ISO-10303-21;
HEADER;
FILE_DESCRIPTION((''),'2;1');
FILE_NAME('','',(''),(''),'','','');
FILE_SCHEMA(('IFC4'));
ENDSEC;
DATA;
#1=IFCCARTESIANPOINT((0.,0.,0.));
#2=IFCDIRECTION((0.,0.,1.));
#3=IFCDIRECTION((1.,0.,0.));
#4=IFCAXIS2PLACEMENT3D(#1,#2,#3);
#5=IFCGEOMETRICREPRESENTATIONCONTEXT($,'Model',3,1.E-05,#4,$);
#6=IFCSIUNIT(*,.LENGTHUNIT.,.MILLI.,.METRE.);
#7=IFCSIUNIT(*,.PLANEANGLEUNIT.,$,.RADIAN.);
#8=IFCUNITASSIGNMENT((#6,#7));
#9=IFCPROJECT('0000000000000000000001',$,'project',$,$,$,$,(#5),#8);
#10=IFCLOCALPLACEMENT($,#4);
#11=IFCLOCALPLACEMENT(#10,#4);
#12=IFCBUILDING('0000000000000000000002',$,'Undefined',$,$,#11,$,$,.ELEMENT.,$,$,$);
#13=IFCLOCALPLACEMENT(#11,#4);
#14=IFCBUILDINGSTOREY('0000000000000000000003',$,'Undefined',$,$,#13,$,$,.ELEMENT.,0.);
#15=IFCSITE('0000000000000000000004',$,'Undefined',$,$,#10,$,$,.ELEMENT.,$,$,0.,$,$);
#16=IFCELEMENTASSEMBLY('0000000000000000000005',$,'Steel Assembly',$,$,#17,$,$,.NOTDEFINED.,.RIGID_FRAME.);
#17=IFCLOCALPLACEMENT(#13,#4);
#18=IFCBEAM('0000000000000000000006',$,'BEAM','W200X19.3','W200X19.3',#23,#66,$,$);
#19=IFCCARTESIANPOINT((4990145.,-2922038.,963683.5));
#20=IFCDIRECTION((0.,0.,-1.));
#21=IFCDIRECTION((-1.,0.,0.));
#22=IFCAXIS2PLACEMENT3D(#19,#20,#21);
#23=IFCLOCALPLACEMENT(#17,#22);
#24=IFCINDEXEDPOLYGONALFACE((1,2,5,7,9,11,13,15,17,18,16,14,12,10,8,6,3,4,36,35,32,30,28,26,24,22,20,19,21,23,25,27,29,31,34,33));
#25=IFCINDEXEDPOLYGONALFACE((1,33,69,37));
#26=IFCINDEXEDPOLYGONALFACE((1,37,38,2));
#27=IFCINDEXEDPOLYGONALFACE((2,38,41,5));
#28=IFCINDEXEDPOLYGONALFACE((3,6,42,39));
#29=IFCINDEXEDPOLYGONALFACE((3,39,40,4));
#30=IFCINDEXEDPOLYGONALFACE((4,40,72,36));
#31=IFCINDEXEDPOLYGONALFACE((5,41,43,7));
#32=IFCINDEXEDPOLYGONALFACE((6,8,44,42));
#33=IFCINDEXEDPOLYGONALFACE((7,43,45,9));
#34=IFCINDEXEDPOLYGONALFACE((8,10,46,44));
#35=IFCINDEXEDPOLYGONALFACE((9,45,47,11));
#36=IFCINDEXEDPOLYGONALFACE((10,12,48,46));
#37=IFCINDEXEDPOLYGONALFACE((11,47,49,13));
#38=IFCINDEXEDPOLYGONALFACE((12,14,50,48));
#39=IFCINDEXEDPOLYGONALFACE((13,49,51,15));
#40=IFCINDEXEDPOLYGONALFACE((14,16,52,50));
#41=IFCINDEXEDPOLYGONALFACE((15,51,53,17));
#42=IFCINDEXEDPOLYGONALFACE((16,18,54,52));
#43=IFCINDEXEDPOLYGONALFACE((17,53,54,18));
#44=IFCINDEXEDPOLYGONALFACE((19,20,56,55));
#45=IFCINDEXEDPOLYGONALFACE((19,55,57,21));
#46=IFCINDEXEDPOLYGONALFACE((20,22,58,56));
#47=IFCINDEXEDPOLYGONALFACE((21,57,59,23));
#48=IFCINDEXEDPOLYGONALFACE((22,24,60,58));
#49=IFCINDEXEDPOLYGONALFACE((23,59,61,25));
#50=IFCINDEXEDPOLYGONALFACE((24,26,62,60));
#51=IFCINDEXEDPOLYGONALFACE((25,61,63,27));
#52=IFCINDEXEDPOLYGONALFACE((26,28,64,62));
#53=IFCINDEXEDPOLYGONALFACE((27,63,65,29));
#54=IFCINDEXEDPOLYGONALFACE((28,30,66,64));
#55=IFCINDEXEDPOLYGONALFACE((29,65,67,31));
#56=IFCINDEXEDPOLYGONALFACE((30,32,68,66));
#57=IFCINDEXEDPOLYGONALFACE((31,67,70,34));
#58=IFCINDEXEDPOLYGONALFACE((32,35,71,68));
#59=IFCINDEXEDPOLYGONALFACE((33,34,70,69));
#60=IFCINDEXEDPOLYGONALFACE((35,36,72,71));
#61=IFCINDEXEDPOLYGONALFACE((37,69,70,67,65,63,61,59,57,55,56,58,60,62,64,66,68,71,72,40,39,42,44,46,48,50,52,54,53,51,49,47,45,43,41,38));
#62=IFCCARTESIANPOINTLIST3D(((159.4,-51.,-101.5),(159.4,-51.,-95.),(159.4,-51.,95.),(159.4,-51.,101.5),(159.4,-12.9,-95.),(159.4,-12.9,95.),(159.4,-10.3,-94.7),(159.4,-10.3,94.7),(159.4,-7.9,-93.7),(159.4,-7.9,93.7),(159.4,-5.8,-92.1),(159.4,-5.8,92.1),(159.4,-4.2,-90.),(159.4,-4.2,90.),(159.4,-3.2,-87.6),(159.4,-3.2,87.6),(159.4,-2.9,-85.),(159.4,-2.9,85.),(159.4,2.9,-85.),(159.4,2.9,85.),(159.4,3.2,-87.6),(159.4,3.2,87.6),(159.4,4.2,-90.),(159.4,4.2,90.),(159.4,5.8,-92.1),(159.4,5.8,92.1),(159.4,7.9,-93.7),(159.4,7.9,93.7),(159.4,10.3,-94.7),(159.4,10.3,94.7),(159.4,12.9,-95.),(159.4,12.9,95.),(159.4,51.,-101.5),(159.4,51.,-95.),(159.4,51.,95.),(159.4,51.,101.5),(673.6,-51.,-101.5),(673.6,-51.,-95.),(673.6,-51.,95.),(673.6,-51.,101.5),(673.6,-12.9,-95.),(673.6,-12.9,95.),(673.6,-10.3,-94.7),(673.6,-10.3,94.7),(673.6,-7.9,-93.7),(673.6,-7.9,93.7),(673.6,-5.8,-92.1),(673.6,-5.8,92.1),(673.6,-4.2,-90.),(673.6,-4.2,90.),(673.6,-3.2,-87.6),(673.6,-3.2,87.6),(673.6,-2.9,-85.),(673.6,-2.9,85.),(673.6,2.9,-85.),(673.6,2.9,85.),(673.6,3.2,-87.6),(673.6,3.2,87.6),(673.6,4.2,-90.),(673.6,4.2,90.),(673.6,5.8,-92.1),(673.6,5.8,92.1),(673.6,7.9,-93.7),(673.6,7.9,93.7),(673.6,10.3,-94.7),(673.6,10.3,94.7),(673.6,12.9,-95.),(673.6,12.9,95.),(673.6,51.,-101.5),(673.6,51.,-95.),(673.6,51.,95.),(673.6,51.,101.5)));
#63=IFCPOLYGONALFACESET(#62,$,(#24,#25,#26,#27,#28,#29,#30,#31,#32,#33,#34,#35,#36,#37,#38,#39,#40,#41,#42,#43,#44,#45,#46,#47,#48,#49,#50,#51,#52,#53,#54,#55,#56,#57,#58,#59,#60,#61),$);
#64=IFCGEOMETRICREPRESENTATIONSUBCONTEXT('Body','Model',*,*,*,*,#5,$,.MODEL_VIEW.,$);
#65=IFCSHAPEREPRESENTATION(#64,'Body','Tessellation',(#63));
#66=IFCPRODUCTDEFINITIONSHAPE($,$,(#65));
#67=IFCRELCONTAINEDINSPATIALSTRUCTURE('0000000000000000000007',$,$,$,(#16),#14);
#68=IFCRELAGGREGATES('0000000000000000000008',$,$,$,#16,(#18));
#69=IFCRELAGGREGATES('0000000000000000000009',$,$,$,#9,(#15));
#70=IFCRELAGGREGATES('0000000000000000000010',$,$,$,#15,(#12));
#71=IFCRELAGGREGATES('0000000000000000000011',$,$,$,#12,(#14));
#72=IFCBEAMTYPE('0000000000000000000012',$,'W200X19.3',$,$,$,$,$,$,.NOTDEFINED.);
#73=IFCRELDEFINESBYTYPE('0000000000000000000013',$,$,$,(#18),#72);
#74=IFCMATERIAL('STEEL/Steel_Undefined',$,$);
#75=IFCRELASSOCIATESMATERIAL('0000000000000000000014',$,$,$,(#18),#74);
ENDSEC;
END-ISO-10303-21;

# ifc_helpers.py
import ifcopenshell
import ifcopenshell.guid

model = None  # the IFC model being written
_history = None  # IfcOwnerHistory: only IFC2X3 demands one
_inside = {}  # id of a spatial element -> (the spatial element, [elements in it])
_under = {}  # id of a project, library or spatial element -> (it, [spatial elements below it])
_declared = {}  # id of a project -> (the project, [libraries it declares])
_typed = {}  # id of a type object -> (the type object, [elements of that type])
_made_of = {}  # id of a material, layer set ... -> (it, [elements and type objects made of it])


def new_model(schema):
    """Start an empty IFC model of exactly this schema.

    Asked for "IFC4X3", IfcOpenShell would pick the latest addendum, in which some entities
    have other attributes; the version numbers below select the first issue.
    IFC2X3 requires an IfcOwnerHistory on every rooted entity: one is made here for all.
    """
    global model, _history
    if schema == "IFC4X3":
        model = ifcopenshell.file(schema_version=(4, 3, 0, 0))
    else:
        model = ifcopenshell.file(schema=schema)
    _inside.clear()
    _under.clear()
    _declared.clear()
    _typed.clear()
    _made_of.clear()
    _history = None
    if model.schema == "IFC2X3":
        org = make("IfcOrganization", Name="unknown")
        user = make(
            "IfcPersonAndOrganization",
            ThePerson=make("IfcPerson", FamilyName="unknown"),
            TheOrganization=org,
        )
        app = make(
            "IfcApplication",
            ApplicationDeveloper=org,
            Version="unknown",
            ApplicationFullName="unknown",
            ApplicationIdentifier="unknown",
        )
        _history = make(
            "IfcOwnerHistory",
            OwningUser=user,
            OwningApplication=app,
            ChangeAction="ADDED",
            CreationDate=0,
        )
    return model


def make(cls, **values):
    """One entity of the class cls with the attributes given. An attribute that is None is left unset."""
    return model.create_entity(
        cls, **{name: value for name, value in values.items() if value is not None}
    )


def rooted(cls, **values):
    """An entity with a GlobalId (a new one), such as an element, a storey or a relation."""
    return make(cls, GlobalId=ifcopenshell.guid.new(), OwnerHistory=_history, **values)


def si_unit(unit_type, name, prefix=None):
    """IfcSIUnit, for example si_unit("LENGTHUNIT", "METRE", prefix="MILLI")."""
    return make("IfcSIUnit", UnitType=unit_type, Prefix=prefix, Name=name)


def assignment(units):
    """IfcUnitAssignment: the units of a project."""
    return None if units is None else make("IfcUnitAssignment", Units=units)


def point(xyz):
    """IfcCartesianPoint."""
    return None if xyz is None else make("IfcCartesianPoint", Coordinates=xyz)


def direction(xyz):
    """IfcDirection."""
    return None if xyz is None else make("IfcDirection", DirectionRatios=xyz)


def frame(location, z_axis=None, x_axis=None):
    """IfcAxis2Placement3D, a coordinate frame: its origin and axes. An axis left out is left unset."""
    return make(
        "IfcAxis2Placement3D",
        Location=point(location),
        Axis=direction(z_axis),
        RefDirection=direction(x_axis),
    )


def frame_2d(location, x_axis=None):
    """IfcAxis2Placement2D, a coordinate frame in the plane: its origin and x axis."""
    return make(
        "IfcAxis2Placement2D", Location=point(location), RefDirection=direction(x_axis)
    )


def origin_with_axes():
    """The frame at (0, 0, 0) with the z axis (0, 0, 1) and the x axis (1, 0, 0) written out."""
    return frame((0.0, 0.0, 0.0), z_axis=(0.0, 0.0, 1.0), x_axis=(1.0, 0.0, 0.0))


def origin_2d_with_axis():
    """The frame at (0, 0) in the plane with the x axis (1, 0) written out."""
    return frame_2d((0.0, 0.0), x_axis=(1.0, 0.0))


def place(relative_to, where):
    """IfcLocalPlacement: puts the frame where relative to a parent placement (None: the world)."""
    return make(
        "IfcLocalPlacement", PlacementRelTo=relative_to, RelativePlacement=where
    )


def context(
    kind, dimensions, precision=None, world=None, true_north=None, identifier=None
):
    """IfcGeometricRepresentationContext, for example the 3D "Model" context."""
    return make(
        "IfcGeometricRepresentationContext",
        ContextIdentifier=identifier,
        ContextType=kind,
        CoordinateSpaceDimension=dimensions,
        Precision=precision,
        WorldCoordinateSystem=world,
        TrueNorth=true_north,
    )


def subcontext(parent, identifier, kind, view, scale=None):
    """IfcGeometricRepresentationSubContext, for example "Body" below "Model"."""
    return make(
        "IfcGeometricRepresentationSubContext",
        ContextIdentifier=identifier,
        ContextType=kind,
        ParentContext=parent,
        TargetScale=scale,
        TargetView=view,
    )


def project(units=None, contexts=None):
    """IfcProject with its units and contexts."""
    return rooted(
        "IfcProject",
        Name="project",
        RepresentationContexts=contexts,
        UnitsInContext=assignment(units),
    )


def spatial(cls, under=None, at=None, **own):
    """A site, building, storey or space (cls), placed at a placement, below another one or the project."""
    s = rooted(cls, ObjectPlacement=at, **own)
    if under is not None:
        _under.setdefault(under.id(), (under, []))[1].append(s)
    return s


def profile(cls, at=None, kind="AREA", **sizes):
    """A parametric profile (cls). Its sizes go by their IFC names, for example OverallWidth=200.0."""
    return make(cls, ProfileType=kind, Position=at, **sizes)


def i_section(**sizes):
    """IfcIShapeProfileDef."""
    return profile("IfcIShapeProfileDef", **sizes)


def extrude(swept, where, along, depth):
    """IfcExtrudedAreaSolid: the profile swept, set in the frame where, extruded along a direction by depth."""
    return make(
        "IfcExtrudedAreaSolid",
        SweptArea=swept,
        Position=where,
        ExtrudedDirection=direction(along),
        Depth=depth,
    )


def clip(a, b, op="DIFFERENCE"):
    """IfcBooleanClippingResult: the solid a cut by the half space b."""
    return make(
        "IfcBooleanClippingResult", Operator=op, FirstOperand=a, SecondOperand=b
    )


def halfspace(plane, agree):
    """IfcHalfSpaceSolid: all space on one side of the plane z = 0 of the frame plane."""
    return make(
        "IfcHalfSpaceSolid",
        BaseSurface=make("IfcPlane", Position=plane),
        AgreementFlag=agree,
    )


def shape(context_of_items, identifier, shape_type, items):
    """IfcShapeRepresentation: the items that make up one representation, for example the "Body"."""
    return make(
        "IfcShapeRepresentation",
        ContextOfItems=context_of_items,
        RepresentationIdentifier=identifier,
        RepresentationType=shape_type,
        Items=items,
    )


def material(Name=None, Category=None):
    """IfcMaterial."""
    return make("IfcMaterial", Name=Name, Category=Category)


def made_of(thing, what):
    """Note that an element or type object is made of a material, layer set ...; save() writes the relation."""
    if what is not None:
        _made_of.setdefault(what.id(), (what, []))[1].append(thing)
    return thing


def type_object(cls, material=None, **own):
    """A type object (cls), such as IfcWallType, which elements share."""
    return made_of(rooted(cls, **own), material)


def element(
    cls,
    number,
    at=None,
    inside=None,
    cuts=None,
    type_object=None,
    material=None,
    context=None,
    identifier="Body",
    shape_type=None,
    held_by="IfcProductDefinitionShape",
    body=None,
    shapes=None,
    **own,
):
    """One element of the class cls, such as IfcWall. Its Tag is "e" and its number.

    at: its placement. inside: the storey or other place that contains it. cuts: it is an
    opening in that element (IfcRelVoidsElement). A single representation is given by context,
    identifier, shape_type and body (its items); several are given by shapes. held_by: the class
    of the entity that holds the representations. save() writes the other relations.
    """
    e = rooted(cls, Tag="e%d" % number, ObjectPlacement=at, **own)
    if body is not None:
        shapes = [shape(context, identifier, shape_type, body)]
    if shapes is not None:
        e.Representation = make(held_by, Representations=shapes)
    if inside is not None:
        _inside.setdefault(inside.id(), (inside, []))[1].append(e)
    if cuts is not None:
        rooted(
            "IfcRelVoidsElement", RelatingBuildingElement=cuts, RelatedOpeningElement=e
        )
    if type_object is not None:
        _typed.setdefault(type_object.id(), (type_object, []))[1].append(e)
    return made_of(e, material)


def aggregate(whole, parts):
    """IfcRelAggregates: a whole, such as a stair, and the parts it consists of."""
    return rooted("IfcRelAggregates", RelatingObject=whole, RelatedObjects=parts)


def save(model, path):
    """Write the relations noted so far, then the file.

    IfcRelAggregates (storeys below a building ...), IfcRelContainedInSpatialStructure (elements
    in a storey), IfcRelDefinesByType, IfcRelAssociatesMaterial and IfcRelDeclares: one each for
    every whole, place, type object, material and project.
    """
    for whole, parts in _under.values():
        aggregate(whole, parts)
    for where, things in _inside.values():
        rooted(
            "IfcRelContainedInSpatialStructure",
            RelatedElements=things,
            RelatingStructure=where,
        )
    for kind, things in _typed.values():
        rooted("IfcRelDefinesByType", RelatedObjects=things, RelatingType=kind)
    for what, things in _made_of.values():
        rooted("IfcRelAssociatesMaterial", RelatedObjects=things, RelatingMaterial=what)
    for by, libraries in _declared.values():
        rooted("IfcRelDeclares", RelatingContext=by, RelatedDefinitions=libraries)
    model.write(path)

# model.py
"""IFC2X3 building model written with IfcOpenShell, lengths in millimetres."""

from ifc_helpers import new_model, si_unit, frame, origin_with_axes, origin_2d_with_axis, place, context, subcontext, project, spatial, i_section, extrude, clip, halfspace, material, type_object, element, aggregate, save


model = new_model("IFC2X3")

# Units and contexts
model_context = context("Model", 3, precision=1e-05, world=origin_with_axes())
body_context = subcontext(model_context, "Body", "Model", "MODEL_VIEW")
ifc_project = project(units=[si_unit("LENGTHUNIT", "METRE", prefix="MILLI"), si_unit("PLANEANGLEUNIT", "RADIAN")], contexts=[model_context])

# Site, building, storey
site_placement = place(None, origin_with_axes())
site = spatial("IfcSite", under=ifc_project, at=site_placement, Name="Undefined", CompositionType="ELEMENT", RefElevation=0.0)
building_placement = place(site_placement, origin_with_axes())
building = spatial("IfcBuilding", under=site, at=building_placement, Name="Undefined", CompositionType="ELEMENT")
storey_placement = place(building_placement, origin_with_axes())
storey = spatial("IfcBuildingStorey", under=building, at=storey_placement, Name="Undefined", CompositionType="ELEMENT", Elevation=0.0)

# Element assembly, beam
assembly_1_placement = place(storey_placement, origin_with_axes())
assembly_1 = element("IfcElementAssembly", 1, at=assembly_1_placement, inside=storey, Name="Steel Assembly", AssemblyPlace="NOTDEFINED", PredefinedType="RIGID_FRAME")
ifc_material_1 = material(Name="STEEL/Steel_Undefined")
beam_type = type_object("IfcBeamType", Name="W200X19.3", PredefinedType="NOTDEFINED")
beam_1_placement = place(assembly_1_placement, frame((4990145.0, -2922038.0, 963683.5), z_axis=(0.0, 0.0, -1.0), x_axis=(-1.0, 0.0, 0.0)))
beam_1 = element("IfcBeam", 2, at=beam_1_placement, type_object=beam_type, material=ifc_material_1, Name="BEAM", Description="W200X19.3", ObjectType="W200X19.3", context=body_context, shape_type="Clipping", body=[
    clip(clip(extrude(i_section(OverallWidth=102.0, OverallDepth=203.0, WebThickness=5.8, FlangeThickness=6.5, FilletRadius=10.0, at=origin_2d_with_axis()), frame((673.6, 0.0, 0.0), z_axis=(-1.0, 0.0, 0.0), x_axis=(0.0, -1.0, 0.0)), (0.0, 0.0, 1.0), 514.2), halfspace(frame((673.6, 0.0, -101.5), z_axis=(-1.0, 0.0, 0.0), x_axis=(0.0, 1.0, 0.0)), True)), halfspace(frame((159.4, 0.0, -101.5), z_axis=(1.0, 0.0, 0.0), x_axis=(0.0, -1.0, 0.0)), True)),
])

aggregate(assembly_1, [beam_1])

save(model, "model.ifc")
